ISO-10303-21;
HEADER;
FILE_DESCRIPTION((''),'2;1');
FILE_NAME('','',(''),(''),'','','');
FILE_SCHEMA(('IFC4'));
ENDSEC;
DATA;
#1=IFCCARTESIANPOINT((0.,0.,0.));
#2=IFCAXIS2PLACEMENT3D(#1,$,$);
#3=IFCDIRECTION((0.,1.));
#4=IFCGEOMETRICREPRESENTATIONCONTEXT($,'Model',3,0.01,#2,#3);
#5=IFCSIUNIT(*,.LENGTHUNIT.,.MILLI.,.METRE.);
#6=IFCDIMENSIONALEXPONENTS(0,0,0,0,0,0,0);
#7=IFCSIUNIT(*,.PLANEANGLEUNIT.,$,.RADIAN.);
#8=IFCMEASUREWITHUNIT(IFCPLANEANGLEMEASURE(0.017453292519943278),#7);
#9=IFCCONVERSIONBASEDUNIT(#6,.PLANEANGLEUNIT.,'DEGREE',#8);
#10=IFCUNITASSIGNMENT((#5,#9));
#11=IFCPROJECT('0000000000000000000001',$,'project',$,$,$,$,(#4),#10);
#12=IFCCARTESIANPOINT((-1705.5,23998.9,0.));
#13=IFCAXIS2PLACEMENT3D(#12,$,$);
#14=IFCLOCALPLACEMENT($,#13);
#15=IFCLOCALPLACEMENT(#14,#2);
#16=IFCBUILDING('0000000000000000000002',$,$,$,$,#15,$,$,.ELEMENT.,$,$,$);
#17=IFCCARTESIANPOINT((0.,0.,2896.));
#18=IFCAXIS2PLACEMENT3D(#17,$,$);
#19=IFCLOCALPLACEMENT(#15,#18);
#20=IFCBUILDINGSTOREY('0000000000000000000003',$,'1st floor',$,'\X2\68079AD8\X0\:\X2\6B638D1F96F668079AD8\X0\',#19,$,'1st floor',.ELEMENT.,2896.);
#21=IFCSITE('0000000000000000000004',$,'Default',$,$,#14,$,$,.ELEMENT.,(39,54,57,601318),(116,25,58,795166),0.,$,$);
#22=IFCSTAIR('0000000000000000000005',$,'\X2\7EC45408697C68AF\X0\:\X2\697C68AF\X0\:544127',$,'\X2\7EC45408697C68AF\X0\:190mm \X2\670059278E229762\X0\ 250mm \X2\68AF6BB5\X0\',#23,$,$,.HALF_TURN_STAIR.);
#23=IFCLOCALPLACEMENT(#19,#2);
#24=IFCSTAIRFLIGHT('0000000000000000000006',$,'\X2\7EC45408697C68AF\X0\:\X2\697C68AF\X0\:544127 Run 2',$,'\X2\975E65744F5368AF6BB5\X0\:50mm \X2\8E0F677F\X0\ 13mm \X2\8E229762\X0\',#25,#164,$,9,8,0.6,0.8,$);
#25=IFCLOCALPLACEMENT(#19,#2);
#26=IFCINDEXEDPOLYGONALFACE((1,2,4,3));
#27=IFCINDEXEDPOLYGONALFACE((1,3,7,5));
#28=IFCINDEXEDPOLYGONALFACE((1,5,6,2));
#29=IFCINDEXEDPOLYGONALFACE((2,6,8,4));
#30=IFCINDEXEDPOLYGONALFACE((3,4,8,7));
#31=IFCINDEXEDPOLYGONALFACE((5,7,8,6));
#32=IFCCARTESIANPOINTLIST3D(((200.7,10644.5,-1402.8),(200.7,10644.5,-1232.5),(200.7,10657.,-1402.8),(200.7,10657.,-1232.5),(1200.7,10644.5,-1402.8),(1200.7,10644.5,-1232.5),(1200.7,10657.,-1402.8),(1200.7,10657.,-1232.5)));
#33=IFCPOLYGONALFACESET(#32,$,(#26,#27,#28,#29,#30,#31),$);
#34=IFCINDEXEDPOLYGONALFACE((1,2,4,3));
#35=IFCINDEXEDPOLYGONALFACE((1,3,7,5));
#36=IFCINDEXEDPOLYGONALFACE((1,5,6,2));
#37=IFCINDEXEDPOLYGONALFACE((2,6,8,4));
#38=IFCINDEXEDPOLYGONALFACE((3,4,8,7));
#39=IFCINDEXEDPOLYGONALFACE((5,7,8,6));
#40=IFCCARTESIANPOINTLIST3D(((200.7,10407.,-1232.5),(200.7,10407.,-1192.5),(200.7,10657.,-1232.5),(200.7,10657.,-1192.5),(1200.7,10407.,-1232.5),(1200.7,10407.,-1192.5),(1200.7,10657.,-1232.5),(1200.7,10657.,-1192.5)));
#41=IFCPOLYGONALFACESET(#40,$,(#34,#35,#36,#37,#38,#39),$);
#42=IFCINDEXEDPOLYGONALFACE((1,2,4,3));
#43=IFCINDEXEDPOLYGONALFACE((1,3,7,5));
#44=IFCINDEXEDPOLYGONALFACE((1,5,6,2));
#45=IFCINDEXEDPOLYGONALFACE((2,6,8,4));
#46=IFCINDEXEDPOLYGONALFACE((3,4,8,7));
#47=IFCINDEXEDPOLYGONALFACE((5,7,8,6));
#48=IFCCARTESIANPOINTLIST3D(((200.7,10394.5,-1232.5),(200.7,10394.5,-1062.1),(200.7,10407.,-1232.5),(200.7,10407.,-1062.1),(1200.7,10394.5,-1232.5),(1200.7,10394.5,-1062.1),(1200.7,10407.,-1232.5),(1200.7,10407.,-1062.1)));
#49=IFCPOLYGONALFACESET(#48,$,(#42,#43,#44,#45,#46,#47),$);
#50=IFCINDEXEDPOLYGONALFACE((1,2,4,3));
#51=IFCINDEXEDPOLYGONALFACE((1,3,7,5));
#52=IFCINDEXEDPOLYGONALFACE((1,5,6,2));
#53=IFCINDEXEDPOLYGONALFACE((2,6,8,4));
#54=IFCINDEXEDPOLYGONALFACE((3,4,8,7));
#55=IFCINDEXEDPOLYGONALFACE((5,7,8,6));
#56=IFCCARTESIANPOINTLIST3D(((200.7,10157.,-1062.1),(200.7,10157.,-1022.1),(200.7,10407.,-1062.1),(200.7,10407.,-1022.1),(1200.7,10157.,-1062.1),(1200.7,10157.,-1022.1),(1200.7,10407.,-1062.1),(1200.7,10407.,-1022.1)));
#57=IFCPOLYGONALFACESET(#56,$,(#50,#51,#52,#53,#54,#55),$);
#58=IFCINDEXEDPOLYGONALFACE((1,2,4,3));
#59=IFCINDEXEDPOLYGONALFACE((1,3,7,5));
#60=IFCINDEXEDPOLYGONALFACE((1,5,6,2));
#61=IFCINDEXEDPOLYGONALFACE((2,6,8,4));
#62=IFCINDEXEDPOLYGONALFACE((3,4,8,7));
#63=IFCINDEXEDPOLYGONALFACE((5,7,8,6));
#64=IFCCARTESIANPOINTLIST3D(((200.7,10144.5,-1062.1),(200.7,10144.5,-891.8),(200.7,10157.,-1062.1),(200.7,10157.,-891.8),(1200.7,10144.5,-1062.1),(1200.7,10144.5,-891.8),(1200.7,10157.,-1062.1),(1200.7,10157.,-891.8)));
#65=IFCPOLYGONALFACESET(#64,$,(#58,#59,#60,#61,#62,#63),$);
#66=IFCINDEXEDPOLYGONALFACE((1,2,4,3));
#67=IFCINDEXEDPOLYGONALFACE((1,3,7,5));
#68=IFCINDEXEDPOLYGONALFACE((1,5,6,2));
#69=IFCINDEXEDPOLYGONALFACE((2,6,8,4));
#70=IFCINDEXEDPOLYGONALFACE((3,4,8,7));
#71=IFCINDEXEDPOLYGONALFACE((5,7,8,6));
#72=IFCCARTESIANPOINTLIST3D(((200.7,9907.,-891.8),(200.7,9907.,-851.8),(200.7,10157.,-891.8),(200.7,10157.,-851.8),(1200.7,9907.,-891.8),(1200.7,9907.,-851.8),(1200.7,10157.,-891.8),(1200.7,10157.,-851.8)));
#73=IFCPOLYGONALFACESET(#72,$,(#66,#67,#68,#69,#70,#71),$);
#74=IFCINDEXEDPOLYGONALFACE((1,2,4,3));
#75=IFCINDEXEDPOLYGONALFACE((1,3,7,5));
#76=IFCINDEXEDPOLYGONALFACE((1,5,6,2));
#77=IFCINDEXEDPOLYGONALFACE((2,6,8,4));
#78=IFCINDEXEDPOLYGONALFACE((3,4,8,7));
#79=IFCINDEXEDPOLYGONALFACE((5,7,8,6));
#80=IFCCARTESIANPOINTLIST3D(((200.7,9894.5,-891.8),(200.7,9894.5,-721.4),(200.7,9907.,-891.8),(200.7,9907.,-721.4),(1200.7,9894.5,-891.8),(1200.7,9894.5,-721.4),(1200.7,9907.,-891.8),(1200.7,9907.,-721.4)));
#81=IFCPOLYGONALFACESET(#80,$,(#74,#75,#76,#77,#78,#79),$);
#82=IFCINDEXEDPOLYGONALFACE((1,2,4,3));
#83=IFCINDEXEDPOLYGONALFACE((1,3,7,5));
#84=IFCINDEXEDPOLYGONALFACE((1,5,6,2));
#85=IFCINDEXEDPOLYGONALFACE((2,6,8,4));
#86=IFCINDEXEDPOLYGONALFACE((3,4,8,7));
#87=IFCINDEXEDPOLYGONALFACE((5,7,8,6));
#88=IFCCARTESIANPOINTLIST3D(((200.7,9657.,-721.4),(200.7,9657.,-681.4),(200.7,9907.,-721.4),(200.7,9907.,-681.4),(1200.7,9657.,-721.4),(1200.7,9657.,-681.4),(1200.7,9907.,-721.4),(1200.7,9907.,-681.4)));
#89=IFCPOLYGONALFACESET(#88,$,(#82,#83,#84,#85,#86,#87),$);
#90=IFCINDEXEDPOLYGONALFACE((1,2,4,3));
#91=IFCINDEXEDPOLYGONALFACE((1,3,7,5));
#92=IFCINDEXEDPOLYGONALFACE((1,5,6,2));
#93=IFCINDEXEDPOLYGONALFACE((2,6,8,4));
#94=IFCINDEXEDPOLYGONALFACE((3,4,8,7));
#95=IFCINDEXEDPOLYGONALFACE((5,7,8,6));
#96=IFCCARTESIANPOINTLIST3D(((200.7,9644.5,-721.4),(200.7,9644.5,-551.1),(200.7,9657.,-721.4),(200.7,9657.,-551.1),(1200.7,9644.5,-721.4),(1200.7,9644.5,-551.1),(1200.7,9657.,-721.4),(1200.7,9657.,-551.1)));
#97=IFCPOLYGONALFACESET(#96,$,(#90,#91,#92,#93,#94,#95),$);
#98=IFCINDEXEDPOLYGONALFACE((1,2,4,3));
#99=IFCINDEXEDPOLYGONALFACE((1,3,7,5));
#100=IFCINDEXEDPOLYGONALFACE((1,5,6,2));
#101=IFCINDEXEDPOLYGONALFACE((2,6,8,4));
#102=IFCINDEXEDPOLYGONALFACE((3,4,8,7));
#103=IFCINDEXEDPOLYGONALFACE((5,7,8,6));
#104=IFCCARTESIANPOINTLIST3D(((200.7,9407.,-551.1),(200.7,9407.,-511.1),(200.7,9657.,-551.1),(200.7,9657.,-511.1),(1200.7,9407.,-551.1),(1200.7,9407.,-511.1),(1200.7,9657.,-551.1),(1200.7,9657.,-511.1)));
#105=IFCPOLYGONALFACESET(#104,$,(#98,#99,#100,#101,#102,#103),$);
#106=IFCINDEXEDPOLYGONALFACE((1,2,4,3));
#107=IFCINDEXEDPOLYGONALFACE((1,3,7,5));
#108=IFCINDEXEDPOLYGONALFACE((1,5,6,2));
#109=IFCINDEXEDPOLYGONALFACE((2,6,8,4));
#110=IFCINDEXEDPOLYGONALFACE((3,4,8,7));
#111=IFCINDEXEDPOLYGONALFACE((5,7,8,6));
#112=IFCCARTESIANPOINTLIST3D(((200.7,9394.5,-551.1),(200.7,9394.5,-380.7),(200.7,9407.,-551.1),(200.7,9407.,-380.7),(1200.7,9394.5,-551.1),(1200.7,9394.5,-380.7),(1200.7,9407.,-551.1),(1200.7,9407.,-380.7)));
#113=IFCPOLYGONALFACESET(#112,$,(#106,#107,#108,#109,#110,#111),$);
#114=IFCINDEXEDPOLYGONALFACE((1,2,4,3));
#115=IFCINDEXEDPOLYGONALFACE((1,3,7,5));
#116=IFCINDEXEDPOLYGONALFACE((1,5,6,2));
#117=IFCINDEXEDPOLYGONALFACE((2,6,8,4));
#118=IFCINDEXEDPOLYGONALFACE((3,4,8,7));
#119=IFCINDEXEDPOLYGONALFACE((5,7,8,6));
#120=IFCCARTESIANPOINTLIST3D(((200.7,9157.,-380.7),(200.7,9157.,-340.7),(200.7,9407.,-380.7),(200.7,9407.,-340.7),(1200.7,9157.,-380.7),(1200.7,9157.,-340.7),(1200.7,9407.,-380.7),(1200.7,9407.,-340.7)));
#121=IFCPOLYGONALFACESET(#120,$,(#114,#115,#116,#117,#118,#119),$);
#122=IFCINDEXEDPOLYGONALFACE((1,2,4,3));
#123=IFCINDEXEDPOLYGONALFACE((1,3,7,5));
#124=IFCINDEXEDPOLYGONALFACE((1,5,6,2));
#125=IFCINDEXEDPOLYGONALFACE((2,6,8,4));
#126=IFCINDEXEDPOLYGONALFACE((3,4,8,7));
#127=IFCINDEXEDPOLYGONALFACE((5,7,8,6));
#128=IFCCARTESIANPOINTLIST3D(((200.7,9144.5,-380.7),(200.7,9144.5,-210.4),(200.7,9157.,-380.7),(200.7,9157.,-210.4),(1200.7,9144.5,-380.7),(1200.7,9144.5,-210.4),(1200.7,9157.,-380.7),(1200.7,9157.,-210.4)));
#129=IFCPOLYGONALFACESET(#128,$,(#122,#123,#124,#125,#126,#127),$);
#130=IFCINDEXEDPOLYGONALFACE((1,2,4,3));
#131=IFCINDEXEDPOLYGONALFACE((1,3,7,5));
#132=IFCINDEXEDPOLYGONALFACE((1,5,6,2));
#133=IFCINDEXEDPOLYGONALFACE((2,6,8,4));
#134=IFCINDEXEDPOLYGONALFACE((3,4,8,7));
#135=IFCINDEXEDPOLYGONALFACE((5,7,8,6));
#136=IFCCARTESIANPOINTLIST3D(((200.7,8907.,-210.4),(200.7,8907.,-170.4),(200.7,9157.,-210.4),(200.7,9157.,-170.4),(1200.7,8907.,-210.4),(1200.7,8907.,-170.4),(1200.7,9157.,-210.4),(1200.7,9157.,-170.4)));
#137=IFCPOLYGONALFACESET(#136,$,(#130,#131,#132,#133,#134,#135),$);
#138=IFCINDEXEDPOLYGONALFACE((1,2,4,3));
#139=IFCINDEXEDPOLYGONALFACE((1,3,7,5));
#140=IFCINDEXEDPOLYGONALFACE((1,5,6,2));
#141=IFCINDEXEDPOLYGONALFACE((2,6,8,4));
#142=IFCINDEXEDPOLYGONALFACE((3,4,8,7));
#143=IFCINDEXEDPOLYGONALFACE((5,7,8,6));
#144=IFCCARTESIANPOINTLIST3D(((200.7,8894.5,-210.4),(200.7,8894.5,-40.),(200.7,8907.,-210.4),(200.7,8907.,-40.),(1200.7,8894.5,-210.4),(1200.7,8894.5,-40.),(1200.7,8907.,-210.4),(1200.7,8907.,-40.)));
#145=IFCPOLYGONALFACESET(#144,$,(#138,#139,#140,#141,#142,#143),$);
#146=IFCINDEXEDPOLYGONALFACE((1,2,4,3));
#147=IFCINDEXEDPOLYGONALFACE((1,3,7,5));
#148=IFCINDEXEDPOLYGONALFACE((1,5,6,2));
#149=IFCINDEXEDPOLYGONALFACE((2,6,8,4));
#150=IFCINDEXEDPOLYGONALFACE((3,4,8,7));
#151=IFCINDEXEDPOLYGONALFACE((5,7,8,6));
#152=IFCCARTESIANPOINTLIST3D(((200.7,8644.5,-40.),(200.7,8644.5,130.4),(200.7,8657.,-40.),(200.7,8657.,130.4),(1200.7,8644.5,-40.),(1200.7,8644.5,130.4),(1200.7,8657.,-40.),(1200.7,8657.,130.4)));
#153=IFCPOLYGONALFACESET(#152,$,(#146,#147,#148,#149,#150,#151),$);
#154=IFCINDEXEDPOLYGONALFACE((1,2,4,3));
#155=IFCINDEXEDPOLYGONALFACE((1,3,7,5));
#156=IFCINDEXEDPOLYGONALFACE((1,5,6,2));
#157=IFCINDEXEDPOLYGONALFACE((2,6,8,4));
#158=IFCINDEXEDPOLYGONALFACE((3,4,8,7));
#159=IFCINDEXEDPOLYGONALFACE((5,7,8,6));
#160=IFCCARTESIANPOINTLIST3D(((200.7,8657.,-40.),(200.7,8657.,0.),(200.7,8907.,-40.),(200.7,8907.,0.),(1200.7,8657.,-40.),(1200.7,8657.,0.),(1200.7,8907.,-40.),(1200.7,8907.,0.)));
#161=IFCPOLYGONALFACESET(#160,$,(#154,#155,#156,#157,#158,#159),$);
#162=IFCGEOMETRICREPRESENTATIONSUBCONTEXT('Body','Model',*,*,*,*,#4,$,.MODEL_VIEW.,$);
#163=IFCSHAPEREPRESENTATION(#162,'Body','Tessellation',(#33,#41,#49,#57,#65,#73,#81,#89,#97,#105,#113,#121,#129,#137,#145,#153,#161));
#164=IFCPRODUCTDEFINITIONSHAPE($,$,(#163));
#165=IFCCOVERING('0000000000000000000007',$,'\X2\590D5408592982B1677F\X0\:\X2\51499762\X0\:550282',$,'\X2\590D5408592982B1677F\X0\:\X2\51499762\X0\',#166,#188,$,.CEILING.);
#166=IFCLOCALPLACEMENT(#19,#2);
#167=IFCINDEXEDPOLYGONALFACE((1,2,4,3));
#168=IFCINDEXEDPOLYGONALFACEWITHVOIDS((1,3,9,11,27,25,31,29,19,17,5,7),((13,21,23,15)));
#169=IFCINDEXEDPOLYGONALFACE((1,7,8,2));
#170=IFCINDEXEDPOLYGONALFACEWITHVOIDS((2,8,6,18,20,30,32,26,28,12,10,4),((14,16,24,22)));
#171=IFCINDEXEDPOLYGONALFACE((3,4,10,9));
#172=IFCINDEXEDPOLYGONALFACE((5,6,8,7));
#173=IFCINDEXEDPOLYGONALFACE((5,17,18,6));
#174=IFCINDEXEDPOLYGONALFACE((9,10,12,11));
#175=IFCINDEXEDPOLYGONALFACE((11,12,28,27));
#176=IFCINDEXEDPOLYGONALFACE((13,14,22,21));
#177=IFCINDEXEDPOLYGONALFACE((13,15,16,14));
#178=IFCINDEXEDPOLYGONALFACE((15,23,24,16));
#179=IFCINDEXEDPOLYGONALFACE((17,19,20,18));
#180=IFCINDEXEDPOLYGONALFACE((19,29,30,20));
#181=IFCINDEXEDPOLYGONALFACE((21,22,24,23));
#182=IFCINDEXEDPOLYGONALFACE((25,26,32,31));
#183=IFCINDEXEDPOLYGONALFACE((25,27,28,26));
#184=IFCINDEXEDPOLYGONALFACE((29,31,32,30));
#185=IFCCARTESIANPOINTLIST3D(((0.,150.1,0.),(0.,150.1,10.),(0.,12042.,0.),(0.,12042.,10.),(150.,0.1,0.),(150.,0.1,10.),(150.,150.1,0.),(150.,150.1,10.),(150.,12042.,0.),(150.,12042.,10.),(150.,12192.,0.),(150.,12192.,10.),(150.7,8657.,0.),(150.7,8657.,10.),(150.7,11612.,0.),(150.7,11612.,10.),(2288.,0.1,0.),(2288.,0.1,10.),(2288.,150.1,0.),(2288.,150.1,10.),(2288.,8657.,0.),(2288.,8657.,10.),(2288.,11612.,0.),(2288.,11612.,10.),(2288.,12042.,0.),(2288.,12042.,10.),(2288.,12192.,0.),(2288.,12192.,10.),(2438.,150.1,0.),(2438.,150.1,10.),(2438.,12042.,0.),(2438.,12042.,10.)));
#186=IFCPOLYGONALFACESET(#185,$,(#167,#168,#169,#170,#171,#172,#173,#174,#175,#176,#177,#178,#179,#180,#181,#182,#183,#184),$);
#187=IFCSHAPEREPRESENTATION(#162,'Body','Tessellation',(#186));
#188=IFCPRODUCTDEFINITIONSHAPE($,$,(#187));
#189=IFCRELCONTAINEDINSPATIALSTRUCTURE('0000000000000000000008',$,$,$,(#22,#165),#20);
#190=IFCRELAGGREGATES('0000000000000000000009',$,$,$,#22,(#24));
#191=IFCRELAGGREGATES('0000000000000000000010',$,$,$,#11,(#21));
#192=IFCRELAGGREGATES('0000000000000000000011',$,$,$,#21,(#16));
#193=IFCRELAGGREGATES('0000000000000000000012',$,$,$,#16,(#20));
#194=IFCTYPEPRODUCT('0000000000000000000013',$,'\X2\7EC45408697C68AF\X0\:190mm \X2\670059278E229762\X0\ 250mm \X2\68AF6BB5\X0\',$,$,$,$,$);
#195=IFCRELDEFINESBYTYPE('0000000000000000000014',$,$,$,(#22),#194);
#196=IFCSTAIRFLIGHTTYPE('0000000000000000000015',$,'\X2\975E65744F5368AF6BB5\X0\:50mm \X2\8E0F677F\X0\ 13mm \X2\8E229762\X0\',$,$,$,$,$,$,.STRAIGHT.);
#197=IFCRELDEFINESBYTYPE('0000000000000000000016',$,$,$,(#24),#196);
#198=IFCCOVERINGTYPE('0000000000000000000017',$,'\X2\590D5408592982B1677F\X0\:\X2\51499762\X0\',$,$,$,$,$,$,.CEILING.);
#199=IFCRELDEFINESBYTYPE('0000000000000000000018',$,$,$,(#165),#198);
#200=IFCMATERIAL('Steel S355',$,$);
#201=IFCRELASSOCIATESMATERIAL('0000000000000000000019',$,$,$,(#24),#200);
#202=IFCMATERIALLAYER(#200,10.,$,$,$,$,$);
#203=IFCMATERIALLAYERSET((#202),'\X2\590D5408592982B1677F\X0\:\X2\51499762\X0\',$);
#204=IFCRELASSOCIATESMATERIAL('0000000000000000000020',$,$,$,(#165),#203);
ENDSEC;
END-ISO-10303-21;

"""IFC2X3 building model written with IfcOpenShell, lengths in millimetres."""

from ifc_helpers import new_model, entity, si_unit, converted_unit, direction, frame, frame_2d, origin, origin_2d_with_axis, place, context, subcontext, project, spatial, polyline, rectangle, outline, extrude, material, layer, layer_set, layer_usage, type_object, element, aggregate, save


model = new_model("IFC2X3")

# Units and contexts
model_context = context("Model", 3, precision=0.01, world=origin(), true_north=direction((0.0, 1.0)))
body_context = subcontext(model_context, "Body", "Model", "MODEL_VIEW")
ifc_project = project(units=[si_unit("LENGTHUNIT", "METRE", prefix="MILLI"), converted_unit("PLANEANGLEUNIT", "DEGREE", entity("IfcPlaneAngleMeasure", 0.017453292519943278), si_unit("PLANEANGLEUNIT", "RADIAN"), dimensions=[0, 0, 0, 0, 0, 0, 0])], contexts=[model_context])

# Site, building, storey
site_placement = place(None, frame((-1705.5, 23998.9, 0.0)))
site = spatial("IfcSite", under=ifc_project, at=site_placement, Name="Default", CompositionType="ELEMENT", RefLatitude=(39, 54, 57, 601318), RefLongitude=(116, 25, 58, 795166), RefElevation=0.0)
building_placement = place(site_placement, origin())
building = spatial("IfcBuilding", under=site, at=building_placement, CompositionType="ELEMENT")
storey_placement = place(building_placement, frame((0.0, 0.0, 2896.0)))
storey = spatial("IfcBuildingStorey", under=building, at=storey_placement, Name="1st floor", ObjectType="标高:正负零标高", LongName="1st floor", CompositionType="ELEMENT", Elevation=2896.0)

# Shared definitions
ifc_material_1 = material(Name="Steel S355")

# Stair
type_product = type_object("IfcTypeProduct", Name="组合楼梯:190mm 最大踢面 250mm 梯段")
stair_placement = place(storey_placement, origin())
stair = element("IfcStair", 1, at=stair_placement, inside=storey, type_object=type_product, Name="组合楼梯:楼梯:544127", ObjectType="组合楼梯:190mm 最大踢面 250mm 梯段", ShapeType="HALF_TURN_STAIR")

# Stair flight
stair_flight_type = type_object("IfcStairFlightType", Name="非整体梯段:50mm 踏板 13mm 踢面", PredefinedType="STRAIGHT")
stair_flight_1_placement = place(stair_placement, origin())
stair_flight_1 = element("IfcStairFlight", 2, at=stair_flight_1_placement, type_object=stair_flight_type, material=ifc_material_1, Name="组合楼梯:楼梯:544127 Run 2", ObjectType="非整体梯段:50mm 踏板 13mm 踢面", NumberOfRiser=9, NumberOfTreads=8, RiserHeight=0.6, TreadLength=0.8, context=body_context, shape_type="SweptSolid", body=[
    extrude(rectangle(XDim=1000.0, YDim=12.5, at=frame_2d((0.0, 0.0), x_axis=(1.0, 0.0))), frame((700.7, 10650.7, -1402.8)), (0.0, 0.0, 1.0), 170.4),
    extrude(rectangle(XDim=250.0, YDim=1000.0, at=frame_2d((0.0, 0.0), x_axis=(1.0, 0.0))), frame((700.7, 10532.0, -1232.5), z_axis=(0.0, 0.0, 1.0), x_axis=(0.0, 1.0, 0.0)), (0.0, 0.0, 1.0), 40.0),
    extrude(rectangle(XDim=1000.0, YDim=12.5, at=frame_2d((0.0, 0.0), x_axis=(1.0, 0.0))), frame((700.7, 10400.7, -1232.5)), (0.0, 0.0, 1.0), 170.4),
    extrude(rectangle(XDim=250.0, YDim=1000.0, at=origin_2d_with_axis()), frame((700.7, 10282.0, -1062.1), z_axis=(0.0, 0.0, 1.0), x_axis=(0.0, 1.0, 0.0)), (0.0, 0.0, 1.0), 40.0),
    extrude(rectangle(XDim=1000.0, YDim=12.5, at=frame_2d((0.0, 0.0), x_axis=(1.0, 0.0))), frame((700.7, 10150.7, -1062.1)), (0.0, 0.0, 1.0), 170.4),
    extrude(rectangle(XDim=250.0, YDim=1000.0, at=frame_2d((0.0, 0.0), x_axis=(1.0, 0.0))), frame((700.7, 10032.0, -891.8), z_axis=(0.0, 0.0, 1.0), x_axis=(0.0, 1.0, 0.0)), (0.0, 0.0, 1.0), 40.0),
    extrude(rectangle(XDim=1000.0, YDim=12.5, at=frame_2d((0.0, 0.0), x_axis=(1.0, 0.0))), frame((700.7, 9900.7, -891.8)), (0.0, 0.0, 1.0), 170.4),
    extrude(rectangle(XDim=250.0, YDim=1000.0, at=origin_2d_with_axis()), frame((700.7, 9782.0, -721.4), z_axis=(0.0, 0.0, 1.0), x_axis=(0.0, 1.0, 0.0)), (0.0, 0.0, 1.0), 40.0),
    extrude(rectangle(XDim=1000.0, YDim=12.5, at=frame_2d((0.0, 0.0), x_axis=(1.0, 0.0))), frame((700.7, 9650.7, -721.4)), (0.0, 0.0, 1.0), 170.4),
    extrude(rectangle(XDim=250.0, YDim=1000.0, at=origin_2d_with_axis()), frame((700.7, 9532.0, -551.1), z_axis=(0.0, 0.0, 1.0), x_axis=(0.0, 1.0, 0.0)), (0.0, 0.0, 1.0), 40.0),
    extrude(rectangle(XDim=1000.0, YDim=12.5, at=frame_2d((0.0, 0.0), x_axis=(1.0, 0.0))), frame((700.7, 9400.7, -551.1)), (0.0, 0.0, 1.0), 170.4),
    extrude(rectangle(XDim=250.0, YDim=1000.0, at=frame_2d((0.0, 0.0), x_axis=(1.0, 0.0))), frame((700.7, 9282.0, -380.7), z_axis=(0.0, 0.0, 1.0), x_axis=(0.0, 1.0, 0.0)), (0.0, 0.0, 1.0), 40.0),
    extrude(rectangle(XDim=1000.0, YDim=12.5, at=frame_2d((0.0, 0.0), x_axis=(1.0, 0.0))), frame((700.7, 9150.7, -380.7)), (0.0, 0.0, 1.0), 170.4),
    extrude(rectangle(XDim=250.0, YDim=1000.0, at=origin_2d_with_axis()), frame((700.7, 9032.0, -210.4), z_axis=(0.0, 0.0, 1.0), x_axis=(0.0, 1.0, 0.0)), (0.0, 0.0, 1.0), 40.0),
    extrude(rectangle(XDim=1000.0, YDim=12.5, at=frame_2d((0.0, 0.0), x_axis=(1.0, 0.0))), frame((700.7, 8900.7, -210.4)), (0.0, 0.0, 1.0), 170.4),
    extrude(rectangle(XDim=1000.0, YDim=12.5, at=frame_2d((0.0, 0.0), x_axis=(1.0, 0.0))), frame((700.7, 8650.7, -40.0)), (0.0, 0.0, 1.0), 170.4),
    extrude(rectangle(XDim=250.0, YDim=1000.0, at=origin_2d_with_axis()), frame((700.7, 8782.0, -40.0), z_axis=(0.0, 0.0, 1.0), x_axis=(0.0, 1.0, 0.0)), (0.0, 0.0, 1.0), 40.0),
])
aggregate(stair, [stair_flight_1])

# Covering
ifc_layer_1 = layer(ifc_material_1, 10.0)
ifc_layer_set_1 = layer_set([ifc_layer_1], Name="复合天花板:光面")
ifc_layer_usage_1 = layer_usage(ifc_layer_set_1, "AXIS3", "NEGATIVE", 10.0)
covering_type = type_object("IfcCoveringType", Name="复合天花板:光面", PredefinedType="CEILING")
covering_placement = place(storey_placement, origin())
element("IfcCovering", 3, at=covering_placement, inside=storey, type_object=covering_type, material=ifc_layer_usage_1, Name="复合天花板:光面:550282", ObjectType="复合天花板:光面", PredefinedType="CEILING", context=body_context, shape_type="SweptSolid", body=[
    extrude(outline(polyline([(5946.0, -1069.0), (6096.0, -1069.0), (6096.0, 1069.0), (5945.9, 1069.0), (5945.9, 1219.0), (-5946.0, 1219.0), (-5946.0, 1069.0), (-6096.0, 1069.0), (-6096.0, -1069.0), (-5946.0, -1069.0), (-5946.0, -1219.0), (5946.0, -1219.0), (5946.0, -1069.0)]), holes=[polyline([(5516.0, 1068.3), (5516.0, -1069.0), (2561.0, -1069.0), (2561.0, 1068.3), (5516.0, 1068.3)])]), frame((1219.0, 6096.0, 0.0), z_axis=(0.0, 0.0, 1.0), x_axis=(0.0, 1.0, 0.0)), (0.0, 0.0, 1.0), 10.0),
])

save(model, "model.ifc")
